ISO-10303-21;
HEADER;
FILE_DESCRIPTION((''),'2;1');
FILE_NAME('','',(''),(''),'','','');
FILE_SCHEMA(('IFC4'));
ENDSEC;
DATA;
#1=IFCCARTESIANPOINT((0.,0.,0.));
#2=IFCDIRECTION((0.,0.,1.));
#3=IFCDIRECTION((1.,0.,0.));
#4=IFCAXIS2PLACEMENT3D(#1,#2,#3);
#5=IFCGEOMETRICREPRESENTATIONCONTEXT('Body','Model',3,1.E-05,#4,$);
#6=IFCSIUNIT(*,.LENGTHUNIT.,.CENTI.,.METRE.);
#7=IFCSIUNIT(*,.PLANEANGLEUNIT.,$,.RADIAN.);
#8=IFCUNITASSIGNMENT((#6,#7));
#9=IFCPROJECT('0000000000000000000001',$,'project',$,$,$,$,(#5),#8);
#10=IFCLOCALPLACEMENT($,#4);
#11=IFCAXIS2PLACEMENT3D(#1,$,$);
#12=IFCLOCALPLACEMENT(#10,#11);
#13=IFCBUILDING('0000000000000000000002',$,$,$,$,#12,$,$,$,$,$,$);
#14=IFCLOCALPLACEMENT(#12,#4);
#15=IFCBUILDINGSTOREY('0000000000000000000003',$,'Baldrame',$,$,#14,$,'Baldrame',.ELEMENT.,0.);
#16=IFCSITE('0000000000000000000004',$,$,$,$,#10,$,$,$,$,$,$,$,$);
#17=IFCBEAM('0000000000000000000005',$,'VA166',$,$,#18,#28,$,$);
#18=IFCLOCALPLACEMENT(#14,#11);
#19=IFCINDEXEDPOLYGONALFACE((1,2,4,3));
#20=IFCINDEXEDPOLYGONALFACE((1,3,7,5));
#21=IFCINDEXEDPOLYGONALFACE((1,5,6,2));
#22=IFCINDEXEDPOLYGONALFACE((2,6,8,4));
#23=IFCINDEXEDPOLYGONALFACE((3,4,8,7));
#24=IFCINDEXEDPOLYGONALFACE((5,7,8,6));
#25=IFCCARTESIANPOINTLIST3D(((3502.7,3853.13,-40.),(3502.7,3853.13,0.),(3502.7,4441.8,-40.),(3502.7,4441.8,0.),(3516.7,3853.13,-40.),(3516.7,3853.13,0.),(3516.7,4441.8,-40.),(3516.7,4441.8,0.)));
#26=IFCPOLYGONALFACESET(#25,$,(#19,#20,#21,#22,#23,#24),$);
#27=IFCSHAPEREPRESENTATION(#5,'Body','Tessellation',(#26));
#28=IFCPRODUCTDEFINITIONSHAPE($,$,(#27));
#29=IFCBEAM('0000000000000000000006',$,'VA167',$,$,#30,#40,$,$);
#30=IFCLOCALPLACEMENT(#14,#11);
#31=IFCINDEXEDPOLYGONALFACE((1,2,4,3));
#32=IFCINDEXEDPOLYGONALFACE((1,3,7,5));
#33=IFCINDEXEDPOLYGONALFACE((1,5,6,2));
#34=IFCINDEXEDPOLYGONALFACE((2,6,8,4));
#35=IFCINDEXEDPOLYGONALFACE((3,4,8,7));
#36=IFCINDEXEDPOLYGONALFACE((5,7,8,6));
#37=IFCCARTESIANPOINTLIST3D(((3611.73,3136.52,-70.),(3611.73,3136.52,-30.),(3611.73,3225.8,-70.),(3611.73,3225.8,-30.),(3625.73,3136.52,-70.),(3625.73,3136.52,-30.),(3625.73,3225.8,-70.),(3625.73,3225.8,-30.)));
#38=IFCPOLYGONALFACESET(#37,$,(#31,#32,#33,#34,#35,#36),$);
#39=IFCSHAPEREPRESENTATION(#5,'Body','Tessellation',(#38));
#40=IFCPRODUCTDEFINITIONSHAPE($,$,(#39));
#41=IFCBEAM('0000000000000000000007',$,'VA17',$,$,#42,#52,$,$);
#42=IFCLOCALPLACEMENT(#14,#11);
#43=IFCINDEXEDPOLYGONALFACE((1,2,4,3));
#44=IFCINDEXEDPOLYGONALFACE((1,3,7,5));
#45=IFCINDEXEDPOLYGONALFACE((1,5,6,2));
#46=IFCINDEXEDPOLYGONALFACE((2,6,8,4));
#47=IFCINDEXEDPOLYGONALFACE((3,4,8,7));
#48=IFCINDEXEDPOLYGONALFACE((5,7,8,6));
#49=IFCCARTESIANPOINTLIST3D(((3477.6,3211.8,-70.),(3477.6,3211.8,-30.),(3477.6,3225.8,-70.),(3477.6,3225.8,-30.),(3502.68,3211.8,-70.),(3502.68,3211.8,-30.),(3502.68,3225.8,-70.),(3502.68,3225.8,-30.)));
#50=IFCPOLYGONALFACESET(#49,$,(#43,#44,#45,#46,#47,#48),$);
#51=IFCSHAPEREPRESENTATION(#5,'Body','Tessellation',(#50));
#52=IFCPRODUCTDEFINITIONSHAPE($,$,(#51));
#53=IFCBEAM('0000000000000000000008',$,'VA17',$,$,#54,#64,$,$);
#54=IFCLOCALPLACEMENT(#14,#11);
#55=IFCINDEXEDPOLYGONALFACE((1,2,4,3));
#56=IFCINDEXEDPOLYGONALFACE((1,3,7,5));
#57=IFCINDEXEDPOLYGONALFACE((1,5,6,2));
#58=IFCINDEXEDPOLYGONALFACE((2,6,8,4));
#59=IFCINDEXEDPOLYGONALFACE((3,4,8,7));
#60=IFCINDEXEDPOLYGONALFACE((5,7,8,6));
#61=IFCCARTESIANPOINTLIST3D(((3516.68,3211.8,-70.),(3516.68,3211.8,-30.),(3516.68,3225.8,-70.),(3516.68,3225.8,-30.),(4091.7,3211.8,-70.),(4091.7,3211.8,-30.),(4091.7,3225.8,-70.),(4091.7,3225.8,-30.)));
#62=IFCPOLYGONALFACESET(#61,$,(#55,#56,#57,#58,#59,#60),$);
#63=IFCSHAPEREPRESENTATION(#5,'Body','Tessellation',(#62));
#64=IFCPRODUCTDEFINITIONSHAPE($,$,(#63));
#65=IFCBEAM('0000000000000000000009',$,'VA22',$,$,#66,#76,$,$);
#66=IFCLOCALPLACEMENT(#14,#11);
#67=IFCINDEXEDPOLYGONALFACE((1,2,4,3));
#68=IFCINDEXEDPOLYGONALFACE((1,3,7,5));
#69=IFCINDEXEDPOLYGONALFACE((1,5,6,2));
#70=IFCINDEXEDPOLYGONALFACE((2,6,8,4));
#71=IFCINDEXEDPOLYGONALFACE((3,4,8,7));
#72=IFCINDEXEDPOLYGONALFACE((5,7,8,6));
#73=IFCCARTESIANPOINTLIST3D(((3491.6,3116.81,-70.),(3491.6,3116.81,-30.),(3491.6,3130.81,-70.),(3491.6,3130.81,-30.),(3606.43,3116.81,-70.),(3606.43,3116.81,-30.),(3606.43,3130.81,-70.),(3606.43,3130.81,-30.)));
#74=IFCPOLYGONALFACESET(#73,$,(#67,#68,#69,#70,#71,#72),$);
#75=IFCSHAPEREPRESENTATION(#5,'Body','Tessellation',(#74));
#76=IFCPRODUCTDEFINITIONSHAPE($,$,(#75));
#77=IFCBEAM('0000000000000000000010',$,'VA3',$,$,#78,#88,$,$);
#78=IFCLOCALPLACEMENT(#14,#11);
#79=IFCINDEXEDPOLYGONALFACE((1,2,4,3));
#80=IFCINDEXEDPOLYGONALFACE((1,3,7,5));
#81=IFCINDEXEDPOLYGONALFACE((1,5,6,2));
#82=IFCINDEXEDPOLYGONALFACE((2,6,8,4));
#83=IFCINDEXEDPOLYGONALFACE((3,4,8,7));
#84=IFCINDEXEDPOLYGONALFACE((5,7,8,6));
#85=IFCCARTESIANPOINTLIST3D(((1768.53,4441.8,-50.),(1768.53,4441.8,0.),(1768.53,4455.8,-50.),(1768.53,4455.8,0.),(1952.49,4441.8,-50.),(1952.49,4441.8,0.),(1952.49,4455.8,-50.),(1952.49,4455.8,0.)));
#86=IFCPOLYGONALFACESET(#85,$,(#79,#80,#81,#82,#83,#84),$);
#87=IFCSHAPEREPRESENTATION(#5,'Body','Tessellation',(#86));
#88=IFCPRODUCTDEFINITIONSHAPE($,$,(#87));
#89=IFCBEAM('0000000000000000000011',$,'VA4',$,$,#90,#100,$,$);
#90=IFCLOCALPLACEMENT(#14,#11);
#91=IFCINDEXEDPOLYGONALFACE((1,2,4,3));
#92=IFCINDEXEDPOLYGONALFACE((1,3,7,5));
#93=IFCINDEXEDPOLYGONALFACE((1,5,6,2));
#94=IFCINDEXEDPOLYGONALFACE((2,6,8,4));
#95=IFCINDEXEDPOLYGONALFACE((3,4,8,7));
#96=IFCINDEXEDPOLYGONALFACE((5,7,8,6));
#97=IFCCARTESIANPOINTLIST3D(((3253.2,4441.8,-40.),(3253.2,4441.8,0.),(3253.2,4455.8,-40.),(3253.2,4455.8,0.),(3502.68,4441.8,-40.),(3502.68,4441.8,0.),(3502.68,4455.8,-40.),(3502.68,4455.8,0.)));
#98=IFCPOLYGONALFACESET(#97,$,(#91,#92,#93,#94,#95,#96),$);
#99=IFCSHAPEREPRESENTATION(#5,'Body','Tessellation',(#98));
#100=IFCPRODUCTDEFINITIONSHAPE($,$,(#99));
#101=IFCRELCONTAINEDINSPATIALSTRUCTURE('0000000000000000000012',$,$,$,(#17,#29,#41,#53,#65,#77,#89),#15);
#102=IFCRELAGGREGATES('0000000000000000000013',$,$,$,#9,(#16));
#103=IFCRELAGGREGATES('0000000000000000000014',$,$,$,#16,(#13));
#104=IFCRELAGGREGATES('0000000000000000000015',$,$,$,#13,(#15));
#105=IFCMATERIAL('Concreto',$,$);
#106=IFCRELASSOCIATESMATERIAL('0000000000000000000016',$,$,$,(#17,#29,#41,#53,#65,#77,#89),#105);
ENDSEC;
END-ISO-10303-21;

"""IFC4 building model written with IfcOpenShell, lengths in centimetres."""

from ifc_helpers import new_model, si_unit, frame, origin, origin_with_axes, origin_2d_with_axis, place, context, project, spatial, rectangle, extrude, material, element, save


model = new_model("IFC4")

# Units and contexts
model_context = context("Model", 3, precision=1e-05, world=origin_with_axes(), identifier="Body")
ifc_project = project(units=[si_unit("LENGTHUNIT", "METRE", prefix="CENTI"), si_unit("PLANEANGLEUNIT", "RADIAN")], contexts=[model_context])

# Site, building, storey
site_placement = place(None, origin_with_axes())
site = spatial("IfcSite", under=ifc_project, at=site_placement)
building_placement = place(site_placement, origin())
building = spatial("IfcBuilding", under=site, at=building_placement)
storey_placement = place(building_placement, origin_with_axes())
storey = spatial("IfcBuildingStorey", under=building, at=storey_placement, Name="Baldrame", LongName="Baldrame", CompositionType="ELEMENT", Elevation=0.0)

# Shared definitions
ifc_material = material(Name="Concreto")

# Beams
beam_1_placement = place(storey_placement, frame((3509.7, 4147.47, 0.0), z_axis=(0.0, 0.0, 1.0), x_axis=(1.0, 0.0, 0.0)))
element("IfcBeam", 1, at=beam_1_placement, inside=storey, material=ifc_material, Name="VA166", context=model_context, shape_type="SolidModel", body=[
    extrude(rectangle(XDim=14.0, YDim=40.0, at=origin_2d_with_axis()), frame((0.0, -294.33, -20.0), z_axis=(0.0, 1.0, 0.0), x_axis=(1.0, 0.0, 0.0)), (0.0, 0.0, 1.0), 588.67),
])
beam_2_placement = place(storey_placement, frame((3618.73, 3181.16, -30.0), z_axis=(0.0, 0.0, 1.0), x_axis=(1.0, 0.0, 0.0)))
element("IfcBeam", 2, at=beam_2_placement, inside=storey, material=ifc_material, Name="VA167", context=model_context, shape_type="SolidModel", body=[
    extrude(rectangle(XDim=14.0, YDim=40.0, at=origin_2d_with_axis()), frame((0.0, -44.64, -20.0), z_axis=(0.0, 1.0, 0.0), x_axis=(1.0, 0.0, 0.0)), (0.0, 0.0, 1.0), 89.28),
])
beam_3_placement = place(storey_placement, frame((3490.14, 3218.8, -30.0), z_axis=(0.0, 0.0, 1.0), x_axis=(1.0, 0.0, 0.0)))
element("IfcBeam", 3, at=beam_3_placement, inside=storey, material=ifc_material, Name="VA17", context=model_context, shape_type="SolidModel", body=[
    extrude(rectangle(XDim=14.0, YDim=40.0, at=origin_2d_with_axis()), frame((-12.54, 0.0, -20.0), z_axis=(1.0, 0.0, 0.0), x_axis=(0.0, 1.0, 0.0)), (0.0, 0.0, 1.0), 25.08),
])
beam_4_placement = place(storey_placement, frame((3804.19, 3218.8, -30.0), z_axis=(0.0, 0.0, 1.0), x_axis=(1.0, 0.0, 0.0)))
element("IfcBeam", 4, at=beam_4_placement, inside=storey, material=ifc_material, Name="VA17", context=model_context, shape_type="SolidModel", body=[
    extrude(rectangle(XDim=14.0, YDim=40.0, at=origin_2d_with_axis()), frame((-287.51, 0.0, -20.0), z_axis=(1.0, 0.0, 0.0), x_axis=(0.0, 1.0, 0.0)), (0.0, 0.0, 1.0), 575.02),
])
beam_5_placement = place(storey_placement, frame((3549.02, 3123.81, -30.0), z_axis=(0.0, 0.0, 1.0), x_axis=(1.0, 0.0, 0.0)))
element("IfcBeam", 5, at=beam_5_placement, inside=storey, material=ifc_material, Name="VA22", context=model_context, shape_type="SolidModel", body=[
    extrude(rectangle(XDim=14.0, YDim=40.0, at=origin_2d_with_axis()), frame((-57.42, 0.0, -20.0), z_axis=(1.0, 0.0, 0.0), x_axis=(0.0, 1.0, 0.0)), (0.0, 0.0, 1.0), 114.83),
])
beam_6_placement = place(storey_placement, frame((1860.51, 4448.8, 0.0), z_axis=(0.0, 0.0, 1.0), x_axis=(1.0, 0.0, 0.0)))
element("IfcBeam", 6, at=beam_6_placement, inside=storey, material=ifc_material, Name="VA3", context=model_context, shape_type="SolidModel", body=[
    extrude(rectangle(XDim=14.0, YDim=50.0, at=origin_2d_with_axis()), frame((-91.98, 0.0, -25.0), z_axis=(1.0, 0.0, 0.0), x_axis=(0.0, 1.0, 0.0)), (0.0, 0.0, 1.0), 183.96),
])
beam_7_placement = place(storey_placement, frame((3377.94, 4448.8, 0.0), z_axis=(0.0, 0.0, 1.0), x_axis=(1.0, 0.0, 0.0)))
element("IfcBeam", 7, at=beam_7_placement, inside=storey, material=ifc_material, Name="VA4", context=model_context, shape_type="SolidModel", body=[
    extrude(rectangle(XDim=14.0, YDim=40.0, at=origin_2d_with_axis()), frame((-124.74, 0.0, -20.0), z_axis=(1.0, 0.0, 0.0), x_axis=(0.0, 1.0, 0.0)), (0.0, 0.0, 1.0), 249.48),
])

save(model, "model.ifc")
